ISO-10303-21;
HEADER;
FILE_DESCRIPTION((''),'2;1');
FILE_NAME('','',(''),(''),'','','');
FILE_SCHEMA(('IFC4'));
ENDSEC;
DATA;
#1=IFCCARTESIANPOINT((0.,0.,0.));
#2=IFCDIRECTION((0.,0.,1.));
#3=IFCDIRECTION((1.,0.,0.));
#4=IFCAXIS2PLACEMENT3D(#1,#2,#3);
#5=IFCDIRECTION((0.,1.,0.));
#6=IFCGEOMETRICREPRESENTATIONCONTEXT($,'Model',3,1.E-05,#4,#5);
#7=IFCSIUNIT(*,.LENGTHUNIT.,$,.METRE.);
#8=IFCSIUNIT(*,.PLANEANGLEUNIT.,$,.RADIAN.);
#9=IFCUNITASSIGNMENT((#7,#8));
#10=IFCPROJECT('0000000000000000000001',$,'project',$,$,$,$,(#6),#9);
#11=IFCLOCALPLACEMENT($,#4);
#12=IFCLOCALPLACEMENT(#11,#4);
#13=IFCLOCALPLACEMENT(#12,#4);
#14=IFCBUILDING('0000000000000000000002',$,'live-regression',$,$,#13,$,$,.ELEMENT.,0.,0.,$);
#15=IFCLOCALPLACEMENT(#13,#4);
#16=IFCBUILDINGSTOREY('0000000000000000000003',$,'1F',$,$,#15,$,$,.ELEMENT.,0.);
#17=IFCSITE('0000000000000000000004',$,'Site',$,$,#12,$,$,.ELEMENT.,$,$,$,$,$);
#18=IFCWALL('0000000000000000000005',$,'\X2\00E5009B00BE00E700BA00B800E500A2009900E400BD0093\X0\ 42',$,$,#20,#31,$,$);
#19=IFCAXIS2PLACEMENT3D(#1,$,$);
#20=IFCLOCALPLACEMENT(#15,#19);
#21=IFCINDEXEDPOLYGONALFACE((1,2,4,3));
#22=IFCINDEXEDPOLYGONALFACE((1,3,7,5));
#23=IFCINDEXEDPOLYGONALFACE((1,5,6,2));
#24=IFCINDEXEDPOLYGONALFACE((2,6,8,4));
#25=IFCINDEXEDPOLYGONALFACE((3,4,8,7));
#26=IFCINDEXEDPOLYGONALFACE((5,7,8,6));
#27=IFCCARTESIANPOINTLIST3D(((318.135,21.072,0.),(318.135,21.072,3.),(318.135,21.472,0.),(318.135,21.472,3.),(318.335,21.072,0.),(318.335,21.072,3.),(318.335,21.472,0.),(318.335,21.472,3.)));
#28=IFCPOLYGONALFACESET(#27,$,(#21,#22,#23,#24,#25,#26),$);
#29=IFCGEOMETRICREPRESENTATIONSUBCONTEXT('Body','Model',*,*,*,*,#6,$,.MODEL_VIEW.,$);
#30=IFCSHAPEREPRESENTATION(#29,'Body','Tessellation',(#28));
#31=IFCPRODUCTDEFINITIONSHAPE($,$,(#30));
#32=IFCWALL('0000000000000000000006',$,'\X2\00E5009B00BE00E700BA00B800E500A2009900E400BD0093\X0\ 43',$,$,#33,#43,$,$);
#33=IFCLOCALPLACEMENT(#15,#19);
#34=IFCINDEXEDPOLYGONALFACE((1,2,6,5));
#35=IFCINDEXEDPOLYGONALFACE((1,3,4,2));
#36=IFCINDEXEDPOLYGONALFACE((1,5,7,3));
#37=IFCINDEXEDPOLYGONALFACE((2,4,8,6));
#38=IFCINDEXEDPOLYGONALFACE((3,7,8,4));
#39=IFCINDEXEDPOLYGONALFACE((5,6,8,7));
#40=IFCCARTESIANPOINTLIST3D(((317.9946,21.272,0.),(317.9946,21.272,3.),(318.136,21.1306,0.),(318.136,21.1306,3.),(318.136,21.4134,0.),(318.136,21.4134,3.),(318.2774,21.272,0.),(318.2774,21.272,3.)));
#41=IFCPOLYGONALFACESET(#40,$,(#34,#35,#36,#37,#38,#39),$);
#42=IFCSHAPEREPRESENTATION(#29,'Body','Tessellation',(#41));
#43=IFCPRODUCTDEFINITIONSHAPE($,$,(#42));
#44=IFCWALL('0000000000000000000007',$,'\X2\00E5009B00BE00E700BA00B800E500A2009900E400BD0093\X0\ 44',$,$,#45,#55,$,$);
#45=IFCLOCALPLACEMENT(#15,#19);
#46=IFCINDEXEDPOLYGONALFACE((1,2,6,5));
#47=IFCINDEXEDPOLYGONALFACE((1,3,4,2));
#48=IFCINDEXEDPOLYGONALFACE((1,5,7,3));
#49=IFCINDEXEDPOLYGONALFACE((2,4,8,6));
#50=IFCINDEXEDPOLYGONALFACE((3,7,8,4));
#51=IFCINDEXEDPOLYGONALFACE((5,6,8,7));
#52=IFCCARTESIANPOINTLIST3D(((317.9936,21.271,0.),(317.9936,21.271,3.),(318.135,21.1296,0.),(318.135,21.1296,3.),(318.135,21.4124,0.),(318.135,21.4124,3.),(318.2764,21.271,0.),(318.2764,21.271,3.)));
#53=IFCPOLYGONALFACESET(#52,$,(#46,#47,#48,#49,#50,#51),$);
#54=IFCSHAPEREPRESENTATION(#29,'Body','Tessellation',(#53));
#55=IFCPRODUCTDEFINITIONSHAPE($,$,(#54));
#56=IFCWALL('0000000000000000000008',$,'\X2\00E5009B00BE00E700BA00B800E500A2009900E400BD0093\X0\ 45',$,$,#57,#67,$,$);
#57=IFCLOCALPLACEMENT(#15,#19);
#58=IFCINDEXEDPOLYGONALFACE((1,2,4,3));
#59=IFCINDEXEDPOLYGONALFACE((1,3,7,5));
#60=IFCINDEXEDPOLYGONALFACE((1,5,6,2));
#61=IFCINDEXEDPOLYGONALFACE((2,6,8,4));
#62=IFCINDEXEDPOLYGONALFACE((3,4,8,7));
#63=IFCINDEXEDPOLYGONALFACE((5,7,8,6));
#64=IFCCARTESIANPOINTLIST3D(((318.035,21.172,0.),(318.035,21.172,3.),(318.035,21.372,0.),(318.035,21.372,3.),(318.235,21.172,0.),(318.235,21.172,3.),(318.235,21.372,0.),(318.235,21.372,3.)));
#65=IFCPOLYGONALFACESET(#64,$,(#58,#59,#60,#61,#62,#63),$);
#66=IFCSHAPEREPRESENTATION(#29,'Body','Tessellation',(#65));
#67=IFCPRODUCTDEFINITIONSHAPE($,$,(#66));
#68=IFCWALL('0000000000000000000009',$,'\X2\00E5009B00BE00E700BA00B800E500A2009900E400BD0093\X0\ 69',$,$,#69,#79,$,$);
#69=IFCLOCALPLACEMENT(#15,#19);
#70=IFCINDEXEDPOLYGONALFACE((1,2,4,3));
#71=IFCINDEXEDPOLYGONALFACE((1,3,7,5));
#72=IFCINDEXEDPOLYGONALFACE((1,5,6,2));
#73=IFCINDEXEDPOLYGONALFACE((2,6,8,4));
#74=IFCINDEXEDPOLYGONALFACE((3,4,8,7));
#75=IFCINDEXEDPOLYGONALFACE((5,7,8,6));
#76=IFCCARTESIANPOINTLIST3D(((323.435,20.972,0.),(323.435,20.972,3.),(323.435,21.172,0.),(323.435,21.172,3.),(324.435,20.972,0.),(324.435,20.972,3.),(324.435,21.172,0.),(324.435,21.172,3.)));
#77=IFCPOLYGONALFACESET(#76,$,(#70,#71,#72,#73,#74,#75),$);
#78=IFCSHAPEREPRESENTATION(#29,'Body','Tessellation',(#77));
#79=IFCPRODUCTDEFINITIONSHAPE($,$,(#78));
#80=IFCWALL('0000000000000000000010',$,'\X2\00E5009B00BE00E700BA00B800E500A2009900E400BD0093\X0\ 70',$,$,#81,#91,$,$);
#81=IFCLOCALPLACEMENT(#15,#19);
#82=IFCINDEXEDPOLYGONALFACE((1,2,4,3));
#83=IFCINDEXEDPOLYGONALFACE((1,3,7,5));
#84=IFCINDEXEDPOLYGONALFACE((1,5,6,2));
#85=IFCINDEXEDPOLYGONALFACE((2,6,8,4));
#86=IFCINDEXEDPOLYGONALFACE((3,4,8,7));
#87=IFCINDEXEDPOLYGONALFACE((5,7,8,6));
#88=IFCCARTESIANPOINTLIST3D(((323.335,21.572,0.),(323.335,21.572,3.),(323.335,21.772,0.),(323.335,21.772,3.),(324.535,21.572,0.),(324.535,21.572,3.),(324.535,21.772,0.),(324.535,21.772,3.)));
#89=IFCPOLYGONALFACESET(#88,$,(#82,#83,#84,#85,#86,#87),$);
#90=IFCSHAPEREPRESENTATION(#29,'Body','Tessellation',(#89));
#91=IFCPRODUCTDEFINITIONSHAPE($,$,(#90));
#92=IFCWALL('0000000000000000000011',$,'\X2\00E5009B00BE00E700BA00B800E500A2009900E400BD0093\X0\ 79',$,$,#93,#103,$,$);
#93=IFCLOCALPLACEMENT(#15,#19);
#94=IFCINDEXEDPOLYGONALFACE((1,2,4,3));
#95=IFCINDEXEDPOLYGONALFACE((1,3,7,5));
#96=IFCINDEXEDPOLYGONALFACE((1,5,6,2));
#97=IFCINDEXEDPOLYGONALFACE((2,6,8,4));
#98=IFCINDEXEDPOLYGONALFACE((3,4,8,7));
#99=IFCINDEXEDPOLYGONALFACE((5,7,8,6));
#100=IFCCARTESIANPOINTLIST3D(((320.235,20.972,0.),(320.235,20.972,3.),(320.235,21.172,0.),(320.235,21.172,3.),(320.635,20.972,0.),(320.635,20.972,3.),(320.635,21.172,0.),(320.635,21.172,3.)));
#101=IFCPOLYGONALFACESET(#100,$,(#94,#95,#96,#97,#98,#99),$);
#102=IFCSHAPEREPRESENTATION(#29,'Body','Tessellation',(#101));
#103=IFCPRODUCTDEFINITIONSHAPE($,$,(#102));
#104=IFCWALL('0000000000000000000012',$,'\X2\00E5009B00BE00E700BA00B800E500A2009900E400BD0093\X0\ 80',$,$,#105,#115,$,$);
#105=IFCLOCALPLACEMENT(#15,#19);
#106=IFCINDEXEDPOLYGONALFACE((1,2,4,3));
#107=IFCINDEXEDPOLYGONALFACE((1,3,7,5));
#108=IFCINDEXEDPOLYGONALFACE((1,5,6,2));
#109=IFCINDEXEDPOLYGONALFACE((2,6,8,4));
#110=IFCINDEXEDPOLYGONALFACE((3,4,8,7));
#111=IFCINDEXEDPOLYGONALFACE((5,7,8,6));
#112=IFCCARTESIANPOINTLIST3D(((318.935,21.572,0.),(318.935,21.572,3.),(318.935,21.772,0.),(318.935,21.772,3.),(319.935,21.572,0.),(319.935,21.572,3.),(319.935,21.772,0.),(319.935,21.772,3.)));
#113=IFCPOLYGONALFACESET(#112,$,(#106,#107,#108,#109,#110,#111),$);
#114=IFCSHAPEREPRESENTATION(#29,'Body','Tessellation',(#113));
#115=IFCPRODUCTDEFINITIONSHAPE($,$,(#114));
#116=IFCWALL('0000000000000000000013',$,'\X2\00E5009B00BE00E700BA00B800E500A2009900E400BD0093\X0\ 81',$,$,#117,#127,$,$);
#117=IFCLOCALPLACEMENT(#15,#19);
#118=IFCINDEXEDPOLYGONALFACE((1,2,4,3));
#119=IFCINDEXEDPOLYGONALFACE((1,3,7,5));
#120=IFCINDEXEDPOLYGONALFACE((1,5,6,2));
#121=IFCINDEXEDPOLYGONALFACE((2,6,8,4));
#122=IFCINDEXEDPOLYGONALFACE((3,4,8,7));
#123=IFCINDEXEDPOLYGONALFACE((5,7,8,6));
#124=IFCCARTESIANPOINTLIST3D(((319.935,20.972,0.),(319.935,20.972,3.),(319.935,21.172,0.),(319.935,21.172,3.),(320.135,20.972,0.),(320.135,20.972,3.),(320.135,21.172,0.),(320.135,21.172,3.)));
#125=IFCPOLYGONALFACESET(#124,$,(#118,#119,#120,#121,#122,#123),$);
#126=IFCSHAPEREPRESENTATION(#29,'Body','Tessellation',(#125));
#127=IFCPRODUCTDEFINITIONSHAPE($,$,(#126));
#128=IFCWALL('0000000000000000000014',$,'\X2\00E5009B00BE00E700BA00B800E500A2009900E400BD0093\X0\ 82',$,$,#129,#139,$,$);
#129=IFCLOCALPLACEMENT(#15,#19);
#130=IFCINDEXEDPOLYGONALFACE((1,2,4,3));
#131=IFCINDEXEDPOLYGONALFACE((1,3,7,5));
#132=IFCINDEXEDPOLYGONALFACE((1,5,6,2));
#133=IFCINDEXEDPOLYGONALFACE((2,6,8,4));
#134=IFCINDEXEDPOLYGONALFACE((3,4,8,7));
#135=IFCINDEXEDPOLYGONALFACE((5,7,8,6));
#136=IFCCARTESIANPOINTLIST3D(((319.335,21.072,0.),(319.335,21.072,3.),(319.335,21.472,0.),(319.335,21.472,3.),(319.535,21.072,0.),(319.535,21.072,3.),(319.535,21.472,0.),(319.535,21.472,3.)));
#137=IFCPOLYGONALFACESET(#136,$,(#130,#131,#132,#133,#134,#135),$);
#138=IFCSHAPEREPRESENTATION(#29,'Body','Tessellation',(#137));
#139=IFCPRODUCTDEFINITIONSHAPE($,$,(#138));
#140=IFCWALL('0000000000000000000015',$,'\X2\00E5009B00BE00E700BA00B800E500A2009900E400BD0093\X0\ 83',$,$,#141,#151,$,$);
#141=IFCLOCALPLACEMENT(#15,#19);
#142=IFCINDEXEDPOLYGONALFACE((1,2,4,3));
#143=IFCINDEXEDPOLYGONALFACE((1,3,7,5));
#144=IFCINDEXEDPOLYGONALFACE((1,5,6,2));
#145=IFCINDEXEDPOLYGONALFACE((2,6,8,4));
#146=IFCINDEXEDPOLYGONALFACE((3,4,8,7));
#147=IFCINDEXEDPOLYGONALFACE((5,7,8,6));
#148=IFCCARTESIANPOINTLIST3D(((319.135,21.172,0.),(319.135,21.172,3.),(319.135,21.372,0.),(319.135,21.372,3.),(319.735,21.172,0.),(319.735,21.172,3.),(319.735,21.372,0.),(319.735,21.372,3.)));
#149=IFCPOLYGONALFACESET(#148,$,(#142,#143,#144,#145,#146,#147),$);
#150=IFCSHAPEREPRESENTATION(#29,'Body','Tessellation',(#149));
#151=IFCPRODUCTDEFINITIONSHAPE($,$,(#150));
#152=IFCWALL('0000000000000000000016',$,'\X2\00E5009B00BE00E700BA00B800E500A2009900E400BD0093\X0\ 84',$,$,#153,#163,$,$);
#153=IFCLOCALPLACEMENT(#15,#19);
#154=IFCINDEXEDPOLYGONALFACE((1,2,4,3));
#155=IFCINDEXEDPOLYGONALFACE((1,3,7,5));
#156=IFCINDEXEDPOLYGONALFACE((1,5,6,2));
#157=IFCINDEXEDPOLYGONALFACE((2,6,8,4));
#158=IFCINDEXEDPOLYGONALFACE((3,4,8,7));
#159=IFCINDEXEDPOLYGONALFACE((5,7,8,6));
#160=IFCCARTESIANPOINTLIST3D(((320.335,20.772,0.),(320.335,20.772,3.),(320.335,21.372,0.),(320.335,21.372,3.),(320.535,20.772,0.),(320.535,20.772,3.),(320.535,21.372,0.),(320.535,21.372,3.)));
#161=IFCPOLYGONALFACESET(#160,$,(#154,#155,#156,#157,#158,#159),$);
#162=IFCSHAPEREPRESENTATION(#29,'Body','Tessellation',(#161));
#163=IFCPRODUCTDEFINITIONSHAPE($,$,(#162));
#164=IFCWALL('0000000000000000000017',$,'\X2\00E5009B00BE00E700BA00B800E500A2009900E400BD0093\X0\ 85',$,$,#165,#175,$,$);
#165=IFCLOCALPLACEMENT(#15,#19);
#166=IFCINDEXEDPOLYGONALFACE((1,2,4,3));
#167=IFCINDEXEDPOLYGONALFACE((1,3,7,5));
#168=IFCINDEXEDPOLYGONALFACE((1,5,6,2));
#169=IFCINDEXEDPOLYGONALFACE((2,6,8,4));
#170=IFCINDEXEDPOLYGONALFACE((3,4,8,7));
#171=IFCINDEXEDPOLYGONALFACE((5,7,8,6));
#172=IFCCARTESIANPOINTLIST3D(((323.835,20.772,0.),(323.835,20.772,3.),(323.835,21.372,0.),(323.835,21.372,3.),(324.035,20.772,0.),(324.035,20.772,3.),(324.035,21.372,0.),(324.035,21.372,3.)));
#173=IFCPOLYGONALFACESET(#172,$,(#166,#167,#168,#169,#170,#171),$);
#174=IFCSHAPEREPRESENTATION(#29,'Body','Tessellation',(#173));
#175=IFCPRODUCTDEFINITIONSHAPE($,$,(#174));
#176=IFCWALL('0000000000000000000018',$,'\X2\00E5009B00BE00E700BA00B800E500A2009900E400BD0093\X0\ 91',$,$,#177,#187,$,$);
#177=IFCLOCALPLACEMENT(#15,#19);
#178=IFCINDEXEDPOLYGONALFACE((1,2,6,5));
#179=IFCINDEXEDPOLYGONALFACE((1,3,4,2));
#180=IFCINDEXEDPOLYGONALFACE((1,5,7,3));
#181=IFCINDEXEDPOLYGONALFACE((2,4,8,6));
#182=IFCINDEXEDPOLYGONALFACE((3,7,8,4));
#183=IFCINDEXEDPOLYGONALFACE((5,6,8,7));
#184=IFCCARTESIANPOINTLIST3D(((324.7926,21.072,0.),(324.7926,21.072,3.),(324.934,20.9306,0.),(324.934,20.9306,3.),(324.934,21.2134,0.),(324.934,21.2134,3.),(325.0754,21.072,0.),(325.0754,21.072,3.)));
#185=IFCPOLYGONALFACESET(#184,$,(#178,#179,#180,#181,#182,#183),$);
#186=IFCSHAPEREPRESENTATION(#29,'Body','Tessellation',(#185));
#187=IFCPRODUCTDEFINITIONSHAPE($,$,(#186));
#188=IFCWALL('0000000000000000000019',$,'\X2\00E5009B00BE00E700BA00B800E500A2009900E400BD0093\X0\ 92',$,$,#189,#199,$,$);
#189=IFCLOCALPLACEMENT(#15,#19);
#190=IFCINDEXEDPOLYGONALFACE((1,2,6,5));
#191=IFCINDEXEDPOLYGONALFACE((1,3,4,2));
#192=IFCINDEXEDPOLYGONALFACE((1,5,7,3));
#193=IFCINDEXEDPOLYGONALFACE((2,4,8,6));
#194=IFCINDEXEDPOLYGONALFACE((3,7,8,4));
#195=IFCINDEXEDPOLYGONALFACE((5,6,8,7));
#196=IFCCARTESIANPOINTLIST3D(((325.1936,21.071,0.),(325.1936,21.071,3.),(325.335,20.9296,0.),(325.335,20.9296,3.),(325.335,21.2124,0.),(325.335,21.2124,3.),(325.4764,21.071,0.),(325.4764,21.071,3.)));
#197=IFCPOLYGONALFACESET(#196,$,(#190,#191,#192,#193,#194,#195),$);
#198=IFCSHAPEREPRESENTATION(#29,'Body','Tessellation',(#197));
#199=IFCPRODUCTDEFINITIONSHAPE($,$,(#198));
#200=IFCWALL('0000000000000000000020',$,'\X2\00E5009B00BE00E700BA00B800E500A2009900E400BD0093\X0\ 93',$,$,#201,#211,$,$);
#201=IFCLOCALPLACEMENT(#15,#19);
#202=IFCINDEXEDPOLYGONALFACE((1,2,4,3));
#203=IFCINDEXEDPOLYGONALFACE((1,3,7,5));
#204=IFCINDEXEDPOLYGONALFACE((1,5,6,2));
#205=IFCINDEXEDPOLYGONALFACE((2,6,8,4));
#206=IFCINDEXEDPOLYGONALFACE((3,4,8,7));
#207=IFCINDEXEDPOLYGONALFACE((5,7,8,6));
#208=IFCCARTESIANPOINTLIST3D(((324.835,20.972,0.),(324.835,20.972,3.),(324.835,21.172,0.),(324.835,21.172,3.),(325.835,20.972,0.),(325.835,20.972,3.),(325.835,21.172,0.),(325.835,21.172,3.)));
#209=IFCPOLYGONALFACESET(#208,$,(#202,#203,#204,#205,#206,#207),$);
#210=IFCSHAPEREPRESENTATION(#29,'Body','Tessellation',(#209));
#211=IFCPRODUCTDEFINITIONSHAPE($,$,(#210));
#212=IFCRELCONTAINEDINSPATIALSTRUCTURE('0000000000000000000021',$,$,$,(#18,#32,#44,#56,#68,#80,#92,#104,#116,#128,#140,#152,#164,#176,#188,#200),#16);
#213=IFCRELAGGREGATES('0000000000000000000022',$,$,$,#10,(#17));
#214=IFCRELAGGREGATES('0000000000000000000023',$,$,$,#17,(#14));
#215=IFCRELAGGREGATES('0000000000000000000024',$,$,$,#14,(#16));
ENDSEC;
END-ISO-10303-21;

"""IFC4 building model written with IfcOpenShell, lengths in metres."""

from ifc_helpers import new_model, si_unit, direction, frame, frame_2d, origin_with_axes, place, context, subcontext, project, spatial, rectangle, extrude, element, save


model = new_model("IFC4")

# Units and contexts
model_context = context("Model", 3, precision=1e-05, world=origin_with_axes(), true_north=direction((0.0, 1.0, 0.0)))
body_context = subcontext(model_context, "Body", "Model", "MODEL_VIEW")
ifc_project = project(units=[si_unit("LENGTHUNIT", "METRE"), si_unit("PLANEANGLEUNIT", "RADIAN")], contexts=[model_context])

# Site, building, storey
placement = place(None, origin_with_axes())
site_placement = place(placement, origin_with_axes())
site = spatial("IfcSite", under=ifc_project, at=site_placement, Name="Site", CompositionType="ELEMENT")
building_placement = place(site_placement, origin_with_axes())
building = spatial("IfcBuilding", under=site, at=building_placement, Name="live-regression", CompositionType="ELEMENT", ElevationOfRefHeight=0.0, ElevationOfTerrain=0.0)
storey_placement = place(building_placement, origin_with_axes())
storey = spatial("IfcBuildingStorey", under=building, at=storey_placement, Name="1F", CompositionType="ELEMENT", Elevation=0.0)

# Walls
wall_1_placement = place(storey_placement, frame((318.235, 21.272, 0.0), z_axis=(0.0, 0.0, 1.0), x_axis=(0.0, 1.0, 0.0)))
element("IfcWall", 1, at=wall_1_placement, inside=storey, Name="å\u009b¾çº¸å¢\u0099ä½\u0093 42", context=body_context, shape_type="SweptSolid", body=[
    extrude(rectangle(XDim=0.4, YDim=0.2, at=frame_2d((0.0, 0.0), x_axis=(1.0, 0.0, 0.0))), frame((0.0, 0.0, 0.0), z_axis=(0.0, 0.0, 1.0)), (0.0, 0.0, 1.0), 3.0),
])
for number, where, z_axis, x_axis, name in (
    (2, (318.136, 21.272, 0.0), (0.0, 0.0, 1.0), (-0.707107, -0.707107, 0.0), "å\u009b¾çº¸å¢\u0099ä½\u0093 43"),
    (3, (318.135, 21.271, 0.0), (0.0, 0.0, 1.0), (0.707107, 0.707107, 0.0), "å\u009b¾çº¸å¢\u0099ä½\u0093 44"),
    (4, (318.135, 21.272, 0.0), (0.0, 0.0, 1.0), (1.0, 0.0, 0.0), "å\u009b¾çº¸å¢\u0099ä½\u0093 45"),
):
    element("IfcWall", number, at=place(storey_placement, frame(where, z_axis=z_axis, x_axis=x_axis)), inside=storey, Name=name, context=body_context, shape_type="SweptSolid", body=[
        extrude(rectangle(XDim=0.2, YDim=0.2, at=frame_2d((0.0, 0.0), x_axis=(1.0, 0.0, 0.0))), frame((0.0, 0.0, 0.0), z_axis=(0.0, 0.0, 1.0)), (0.0, 0.0, 1.0), 3.0),
    ])
wall_2_placement = place(storey_placement, frame((323.935, 21.072, 0.0), z_axis=(0.0, 0.0, 1.0), x_axis=(1.0, 0.0, 0.0)))
element("IfcWall", 5, at=wall_2_placement, inside=storey, Name="å\u009b¾çº¸å¢\u0099ä½\u0093 69", context=body_context, shape_type="SweptSolid", body=[
    extrude(rectangle(XDim=1.0, YDim=0.2, at=frame_2d((0.0, 0.0), x_axis=(1.0, 0.0, 0.0))), frame((0.0, 0.0, 0.0), z_axis=(0.0, 0.0, 1.0)), (0.0, 0.0, 1.0), 3.0),
])
wall_3_placement = place(storey_placement, frame((323.935, 21.672, 0.0), z_axis=(0.0, 0.0, 1.0), x_axis=(1.0, 0.0, 0.0)))
element("IfcWall", 6, at=wall_3_placement, inside=storey, Name="å\u009b¾çº¸å¢\u0099ä½\u0093 70", context=body_context, shape_type="SweptSolid", body=[
    extrude(rectangle(XDim=1.2, YDim=0.2, at=frame_2d((0.0, 0.0), x_axis=(1.0, 0.0, 0.0))), frame((0.0, 0.0, 0.0), z_axis=(0.0, 0.0, 1.0)), (0.0, 0.0, 1.0), 3.0),
])
wall_4_placement = place(storey_placement, frame((320.435, 21.072, 0.0), z_axis=(0.0, 0.0, 1.0), x_axis=(-1.0, 0.0, 0.0)))
element("IfcWall", 7, at=wall_4_placement, inside=storey, Name="å\u009b¾çº¸å¢\u0099ä½\u0093 79", context=body_context, shape_type="SweptSolid", body=[
    extrude(rectangle(XDim=0.4, YDim=0.2, at=frame_2d((0.0, 0.0), x_axis=(1.0, 0.0, 0.0))), frame((0.0, 0.0, 0.0), z_axis=(0.0, 0.0, 1.0)), (0.0, 0.0, 1.0), 3.0),
])
wall_5_placement = place(storey_placement, frame((319.435, 21.672, 0.0), z_axis=(0.0, 0.0, 1.0), x_axis=(1.0, 0.0, 0.0)))
element("IfcWall", 8, at=wall_5_placement, inside=storey, Name="å\u009b¾çº¸å¢\u0099ä½\u0093 80", context=body_context, shape_type="SweptSolid", body=[
    extrude(rectangle(XDim=1.0, YDim=0.2, at=frame_2d((0.0, 0.0), x_axis=(1.0, 0.0, 0.0))), frame((0.0, 0.0, 0.0), z_axis=(0.0, 0.0, 1.0)), (0.0, 0.0, 1.0), 3.0),
])
wall_6_placement = place(storey_placement, frame((320.035, 21.072, 0.0), z_axis=(0.0, 0.0, 1.0), x_axis=(0.0, 1.0, 0.0)))
element("IfcWall", 9, at=wall_6_placement, inside=storey, Name="å\u009b¾çº¸å¢\u0099ä½\u0093 81", context=body_context, shape_type="SweptSolid", body=[
    extrude(rectangle(XDim=0.2, YDim=0.2, at=frame_2d((0.0, 0.0), x_axis=(1.0, 0.0, 0.0))), frame((0.0, 0.0, 0.0), z_axis=(0.0, 0.0, 1.0)), (0.0, 0.0, 1.0), 3.0),
])
wall_7_placement = place(storey_placement, frame((319.435, 21.272, 0.0), z_axis=(0.0, 0.0, 1.0), x_axis=(0.0, 1.0, 0.0)))
element("IfcWall", 10, at=wall_7_placement, inside=storey, Name="å\u009b¾çº¸å¢\u0099ä½\u0093 82", context=body_context, shape_type="SweptSolid", body=[
    extrude(rectangle(XDim=0.4, YDim=0.2, at=frame_2d((0.0, 0.0), x_axis=(1.0, 0.0, 0.0))), frame((0.0, 0.0, 0.0), z_axis=(0.0, 0.0, 1.0)), (0.0, 0.0, 1.0), 3.0),
])
for number, where, z_axis, x_axis, name in (
    (11, (319.435, 21.272, 0.0), (0.0, 0.0, 1.0), (1.0, 0.0, 0.0), "å\u009b¾çº¸å¢\u0099ä½\u0093 83"),
    (12, (320.435, 21.072, 0.0), (0.0, 0.0, 1.0), (0.0, 1.0, 0.0), "å\u009b¾çº¸å¢\u0099ä½\u0093 84"),
    (13, (323.935, 21.072, 0.0), (0.0, 0.0, 1.0), (0.0, 1.0, 0.0), "å\u009b¾çº¸å¢\u0099ä½\u0093 85"),
):
    element("IfcWall", number, at=place(storey_placement, frame(where, z_axis=z_axis, x_axis=x_axis)), inside=storey, Name=name, context=body_context, shape_type="SweptSolid", body=[
        extrude(rectangle(XDim=0.6, YDim=0.2, at=frame_2d((0.0, 0.0), x_axis=(1.0, 0.0, 0.0))), frame((0.0, 0.0, 0.0), z_axis=(0.0, 0.0, 1.0)), (0.0, 0.0, 1.0), 3.0),
    ])
for number, where, z_axis, x_axis, name in (
    (14, (324.934, 21.072, 0.0), (0.0, 0.0, 1.0), (0.707107, -0.707107, 0.0), "å\u009b¾çº¸å¢\u0099ä½\u0093 91"),
    (15, (325.335, 21.071, 0.0), (0.0, 0.0, 1.0), (0.707107, 0.707107, 0.0), "å\u009b¾çº¸å¢\u0099ä½\u0093 92"),
):
    element("IfcWall", number, at=place(storey_placement, frame(where, z_axis=z_axis, x_axis=x_axis)), inside=storey, Name=name, context=body_context, shape_type="SweptSolid", body=[
        extrude(rectangle(XDim=0.2, YDim=0.2, at=frame_2d((0.0, 0.0), x_axis=(1.0, 0.0, 0.0))), frame((0.0, 0.0, 0.0), z_axis=(0.0, 0.0, 1.0)), (0.0, 0.0, 1.0), 3.0),
    ])
wall_8_placement = place(storey_placement, frame((325.335, 21.072, 0.0), z_axis=(0.0, 0.0, 1.0), x_axis=(1.0, 0.0, 0.0)))
element("IfcWall", 16, at=wall_8_placement, inside=storey, Name="å\u009b¾çº¸å¢\u0099ä½\u0093 93", context=body_context, shape_type="SweptSolid", body=[
    extrude(rectangle(XDim=1.0, YDim=0.2, at=frame_2d((0.0, 0.0), x_axis=(1.0, 0.0, 0.0))), frame((0.0, 0.0, 0.0), z_axis=(0.0, 0.0, 1.0)), (0.0, 0.0, 1.0), 3.0),
])

save(model, "model.ifc")
